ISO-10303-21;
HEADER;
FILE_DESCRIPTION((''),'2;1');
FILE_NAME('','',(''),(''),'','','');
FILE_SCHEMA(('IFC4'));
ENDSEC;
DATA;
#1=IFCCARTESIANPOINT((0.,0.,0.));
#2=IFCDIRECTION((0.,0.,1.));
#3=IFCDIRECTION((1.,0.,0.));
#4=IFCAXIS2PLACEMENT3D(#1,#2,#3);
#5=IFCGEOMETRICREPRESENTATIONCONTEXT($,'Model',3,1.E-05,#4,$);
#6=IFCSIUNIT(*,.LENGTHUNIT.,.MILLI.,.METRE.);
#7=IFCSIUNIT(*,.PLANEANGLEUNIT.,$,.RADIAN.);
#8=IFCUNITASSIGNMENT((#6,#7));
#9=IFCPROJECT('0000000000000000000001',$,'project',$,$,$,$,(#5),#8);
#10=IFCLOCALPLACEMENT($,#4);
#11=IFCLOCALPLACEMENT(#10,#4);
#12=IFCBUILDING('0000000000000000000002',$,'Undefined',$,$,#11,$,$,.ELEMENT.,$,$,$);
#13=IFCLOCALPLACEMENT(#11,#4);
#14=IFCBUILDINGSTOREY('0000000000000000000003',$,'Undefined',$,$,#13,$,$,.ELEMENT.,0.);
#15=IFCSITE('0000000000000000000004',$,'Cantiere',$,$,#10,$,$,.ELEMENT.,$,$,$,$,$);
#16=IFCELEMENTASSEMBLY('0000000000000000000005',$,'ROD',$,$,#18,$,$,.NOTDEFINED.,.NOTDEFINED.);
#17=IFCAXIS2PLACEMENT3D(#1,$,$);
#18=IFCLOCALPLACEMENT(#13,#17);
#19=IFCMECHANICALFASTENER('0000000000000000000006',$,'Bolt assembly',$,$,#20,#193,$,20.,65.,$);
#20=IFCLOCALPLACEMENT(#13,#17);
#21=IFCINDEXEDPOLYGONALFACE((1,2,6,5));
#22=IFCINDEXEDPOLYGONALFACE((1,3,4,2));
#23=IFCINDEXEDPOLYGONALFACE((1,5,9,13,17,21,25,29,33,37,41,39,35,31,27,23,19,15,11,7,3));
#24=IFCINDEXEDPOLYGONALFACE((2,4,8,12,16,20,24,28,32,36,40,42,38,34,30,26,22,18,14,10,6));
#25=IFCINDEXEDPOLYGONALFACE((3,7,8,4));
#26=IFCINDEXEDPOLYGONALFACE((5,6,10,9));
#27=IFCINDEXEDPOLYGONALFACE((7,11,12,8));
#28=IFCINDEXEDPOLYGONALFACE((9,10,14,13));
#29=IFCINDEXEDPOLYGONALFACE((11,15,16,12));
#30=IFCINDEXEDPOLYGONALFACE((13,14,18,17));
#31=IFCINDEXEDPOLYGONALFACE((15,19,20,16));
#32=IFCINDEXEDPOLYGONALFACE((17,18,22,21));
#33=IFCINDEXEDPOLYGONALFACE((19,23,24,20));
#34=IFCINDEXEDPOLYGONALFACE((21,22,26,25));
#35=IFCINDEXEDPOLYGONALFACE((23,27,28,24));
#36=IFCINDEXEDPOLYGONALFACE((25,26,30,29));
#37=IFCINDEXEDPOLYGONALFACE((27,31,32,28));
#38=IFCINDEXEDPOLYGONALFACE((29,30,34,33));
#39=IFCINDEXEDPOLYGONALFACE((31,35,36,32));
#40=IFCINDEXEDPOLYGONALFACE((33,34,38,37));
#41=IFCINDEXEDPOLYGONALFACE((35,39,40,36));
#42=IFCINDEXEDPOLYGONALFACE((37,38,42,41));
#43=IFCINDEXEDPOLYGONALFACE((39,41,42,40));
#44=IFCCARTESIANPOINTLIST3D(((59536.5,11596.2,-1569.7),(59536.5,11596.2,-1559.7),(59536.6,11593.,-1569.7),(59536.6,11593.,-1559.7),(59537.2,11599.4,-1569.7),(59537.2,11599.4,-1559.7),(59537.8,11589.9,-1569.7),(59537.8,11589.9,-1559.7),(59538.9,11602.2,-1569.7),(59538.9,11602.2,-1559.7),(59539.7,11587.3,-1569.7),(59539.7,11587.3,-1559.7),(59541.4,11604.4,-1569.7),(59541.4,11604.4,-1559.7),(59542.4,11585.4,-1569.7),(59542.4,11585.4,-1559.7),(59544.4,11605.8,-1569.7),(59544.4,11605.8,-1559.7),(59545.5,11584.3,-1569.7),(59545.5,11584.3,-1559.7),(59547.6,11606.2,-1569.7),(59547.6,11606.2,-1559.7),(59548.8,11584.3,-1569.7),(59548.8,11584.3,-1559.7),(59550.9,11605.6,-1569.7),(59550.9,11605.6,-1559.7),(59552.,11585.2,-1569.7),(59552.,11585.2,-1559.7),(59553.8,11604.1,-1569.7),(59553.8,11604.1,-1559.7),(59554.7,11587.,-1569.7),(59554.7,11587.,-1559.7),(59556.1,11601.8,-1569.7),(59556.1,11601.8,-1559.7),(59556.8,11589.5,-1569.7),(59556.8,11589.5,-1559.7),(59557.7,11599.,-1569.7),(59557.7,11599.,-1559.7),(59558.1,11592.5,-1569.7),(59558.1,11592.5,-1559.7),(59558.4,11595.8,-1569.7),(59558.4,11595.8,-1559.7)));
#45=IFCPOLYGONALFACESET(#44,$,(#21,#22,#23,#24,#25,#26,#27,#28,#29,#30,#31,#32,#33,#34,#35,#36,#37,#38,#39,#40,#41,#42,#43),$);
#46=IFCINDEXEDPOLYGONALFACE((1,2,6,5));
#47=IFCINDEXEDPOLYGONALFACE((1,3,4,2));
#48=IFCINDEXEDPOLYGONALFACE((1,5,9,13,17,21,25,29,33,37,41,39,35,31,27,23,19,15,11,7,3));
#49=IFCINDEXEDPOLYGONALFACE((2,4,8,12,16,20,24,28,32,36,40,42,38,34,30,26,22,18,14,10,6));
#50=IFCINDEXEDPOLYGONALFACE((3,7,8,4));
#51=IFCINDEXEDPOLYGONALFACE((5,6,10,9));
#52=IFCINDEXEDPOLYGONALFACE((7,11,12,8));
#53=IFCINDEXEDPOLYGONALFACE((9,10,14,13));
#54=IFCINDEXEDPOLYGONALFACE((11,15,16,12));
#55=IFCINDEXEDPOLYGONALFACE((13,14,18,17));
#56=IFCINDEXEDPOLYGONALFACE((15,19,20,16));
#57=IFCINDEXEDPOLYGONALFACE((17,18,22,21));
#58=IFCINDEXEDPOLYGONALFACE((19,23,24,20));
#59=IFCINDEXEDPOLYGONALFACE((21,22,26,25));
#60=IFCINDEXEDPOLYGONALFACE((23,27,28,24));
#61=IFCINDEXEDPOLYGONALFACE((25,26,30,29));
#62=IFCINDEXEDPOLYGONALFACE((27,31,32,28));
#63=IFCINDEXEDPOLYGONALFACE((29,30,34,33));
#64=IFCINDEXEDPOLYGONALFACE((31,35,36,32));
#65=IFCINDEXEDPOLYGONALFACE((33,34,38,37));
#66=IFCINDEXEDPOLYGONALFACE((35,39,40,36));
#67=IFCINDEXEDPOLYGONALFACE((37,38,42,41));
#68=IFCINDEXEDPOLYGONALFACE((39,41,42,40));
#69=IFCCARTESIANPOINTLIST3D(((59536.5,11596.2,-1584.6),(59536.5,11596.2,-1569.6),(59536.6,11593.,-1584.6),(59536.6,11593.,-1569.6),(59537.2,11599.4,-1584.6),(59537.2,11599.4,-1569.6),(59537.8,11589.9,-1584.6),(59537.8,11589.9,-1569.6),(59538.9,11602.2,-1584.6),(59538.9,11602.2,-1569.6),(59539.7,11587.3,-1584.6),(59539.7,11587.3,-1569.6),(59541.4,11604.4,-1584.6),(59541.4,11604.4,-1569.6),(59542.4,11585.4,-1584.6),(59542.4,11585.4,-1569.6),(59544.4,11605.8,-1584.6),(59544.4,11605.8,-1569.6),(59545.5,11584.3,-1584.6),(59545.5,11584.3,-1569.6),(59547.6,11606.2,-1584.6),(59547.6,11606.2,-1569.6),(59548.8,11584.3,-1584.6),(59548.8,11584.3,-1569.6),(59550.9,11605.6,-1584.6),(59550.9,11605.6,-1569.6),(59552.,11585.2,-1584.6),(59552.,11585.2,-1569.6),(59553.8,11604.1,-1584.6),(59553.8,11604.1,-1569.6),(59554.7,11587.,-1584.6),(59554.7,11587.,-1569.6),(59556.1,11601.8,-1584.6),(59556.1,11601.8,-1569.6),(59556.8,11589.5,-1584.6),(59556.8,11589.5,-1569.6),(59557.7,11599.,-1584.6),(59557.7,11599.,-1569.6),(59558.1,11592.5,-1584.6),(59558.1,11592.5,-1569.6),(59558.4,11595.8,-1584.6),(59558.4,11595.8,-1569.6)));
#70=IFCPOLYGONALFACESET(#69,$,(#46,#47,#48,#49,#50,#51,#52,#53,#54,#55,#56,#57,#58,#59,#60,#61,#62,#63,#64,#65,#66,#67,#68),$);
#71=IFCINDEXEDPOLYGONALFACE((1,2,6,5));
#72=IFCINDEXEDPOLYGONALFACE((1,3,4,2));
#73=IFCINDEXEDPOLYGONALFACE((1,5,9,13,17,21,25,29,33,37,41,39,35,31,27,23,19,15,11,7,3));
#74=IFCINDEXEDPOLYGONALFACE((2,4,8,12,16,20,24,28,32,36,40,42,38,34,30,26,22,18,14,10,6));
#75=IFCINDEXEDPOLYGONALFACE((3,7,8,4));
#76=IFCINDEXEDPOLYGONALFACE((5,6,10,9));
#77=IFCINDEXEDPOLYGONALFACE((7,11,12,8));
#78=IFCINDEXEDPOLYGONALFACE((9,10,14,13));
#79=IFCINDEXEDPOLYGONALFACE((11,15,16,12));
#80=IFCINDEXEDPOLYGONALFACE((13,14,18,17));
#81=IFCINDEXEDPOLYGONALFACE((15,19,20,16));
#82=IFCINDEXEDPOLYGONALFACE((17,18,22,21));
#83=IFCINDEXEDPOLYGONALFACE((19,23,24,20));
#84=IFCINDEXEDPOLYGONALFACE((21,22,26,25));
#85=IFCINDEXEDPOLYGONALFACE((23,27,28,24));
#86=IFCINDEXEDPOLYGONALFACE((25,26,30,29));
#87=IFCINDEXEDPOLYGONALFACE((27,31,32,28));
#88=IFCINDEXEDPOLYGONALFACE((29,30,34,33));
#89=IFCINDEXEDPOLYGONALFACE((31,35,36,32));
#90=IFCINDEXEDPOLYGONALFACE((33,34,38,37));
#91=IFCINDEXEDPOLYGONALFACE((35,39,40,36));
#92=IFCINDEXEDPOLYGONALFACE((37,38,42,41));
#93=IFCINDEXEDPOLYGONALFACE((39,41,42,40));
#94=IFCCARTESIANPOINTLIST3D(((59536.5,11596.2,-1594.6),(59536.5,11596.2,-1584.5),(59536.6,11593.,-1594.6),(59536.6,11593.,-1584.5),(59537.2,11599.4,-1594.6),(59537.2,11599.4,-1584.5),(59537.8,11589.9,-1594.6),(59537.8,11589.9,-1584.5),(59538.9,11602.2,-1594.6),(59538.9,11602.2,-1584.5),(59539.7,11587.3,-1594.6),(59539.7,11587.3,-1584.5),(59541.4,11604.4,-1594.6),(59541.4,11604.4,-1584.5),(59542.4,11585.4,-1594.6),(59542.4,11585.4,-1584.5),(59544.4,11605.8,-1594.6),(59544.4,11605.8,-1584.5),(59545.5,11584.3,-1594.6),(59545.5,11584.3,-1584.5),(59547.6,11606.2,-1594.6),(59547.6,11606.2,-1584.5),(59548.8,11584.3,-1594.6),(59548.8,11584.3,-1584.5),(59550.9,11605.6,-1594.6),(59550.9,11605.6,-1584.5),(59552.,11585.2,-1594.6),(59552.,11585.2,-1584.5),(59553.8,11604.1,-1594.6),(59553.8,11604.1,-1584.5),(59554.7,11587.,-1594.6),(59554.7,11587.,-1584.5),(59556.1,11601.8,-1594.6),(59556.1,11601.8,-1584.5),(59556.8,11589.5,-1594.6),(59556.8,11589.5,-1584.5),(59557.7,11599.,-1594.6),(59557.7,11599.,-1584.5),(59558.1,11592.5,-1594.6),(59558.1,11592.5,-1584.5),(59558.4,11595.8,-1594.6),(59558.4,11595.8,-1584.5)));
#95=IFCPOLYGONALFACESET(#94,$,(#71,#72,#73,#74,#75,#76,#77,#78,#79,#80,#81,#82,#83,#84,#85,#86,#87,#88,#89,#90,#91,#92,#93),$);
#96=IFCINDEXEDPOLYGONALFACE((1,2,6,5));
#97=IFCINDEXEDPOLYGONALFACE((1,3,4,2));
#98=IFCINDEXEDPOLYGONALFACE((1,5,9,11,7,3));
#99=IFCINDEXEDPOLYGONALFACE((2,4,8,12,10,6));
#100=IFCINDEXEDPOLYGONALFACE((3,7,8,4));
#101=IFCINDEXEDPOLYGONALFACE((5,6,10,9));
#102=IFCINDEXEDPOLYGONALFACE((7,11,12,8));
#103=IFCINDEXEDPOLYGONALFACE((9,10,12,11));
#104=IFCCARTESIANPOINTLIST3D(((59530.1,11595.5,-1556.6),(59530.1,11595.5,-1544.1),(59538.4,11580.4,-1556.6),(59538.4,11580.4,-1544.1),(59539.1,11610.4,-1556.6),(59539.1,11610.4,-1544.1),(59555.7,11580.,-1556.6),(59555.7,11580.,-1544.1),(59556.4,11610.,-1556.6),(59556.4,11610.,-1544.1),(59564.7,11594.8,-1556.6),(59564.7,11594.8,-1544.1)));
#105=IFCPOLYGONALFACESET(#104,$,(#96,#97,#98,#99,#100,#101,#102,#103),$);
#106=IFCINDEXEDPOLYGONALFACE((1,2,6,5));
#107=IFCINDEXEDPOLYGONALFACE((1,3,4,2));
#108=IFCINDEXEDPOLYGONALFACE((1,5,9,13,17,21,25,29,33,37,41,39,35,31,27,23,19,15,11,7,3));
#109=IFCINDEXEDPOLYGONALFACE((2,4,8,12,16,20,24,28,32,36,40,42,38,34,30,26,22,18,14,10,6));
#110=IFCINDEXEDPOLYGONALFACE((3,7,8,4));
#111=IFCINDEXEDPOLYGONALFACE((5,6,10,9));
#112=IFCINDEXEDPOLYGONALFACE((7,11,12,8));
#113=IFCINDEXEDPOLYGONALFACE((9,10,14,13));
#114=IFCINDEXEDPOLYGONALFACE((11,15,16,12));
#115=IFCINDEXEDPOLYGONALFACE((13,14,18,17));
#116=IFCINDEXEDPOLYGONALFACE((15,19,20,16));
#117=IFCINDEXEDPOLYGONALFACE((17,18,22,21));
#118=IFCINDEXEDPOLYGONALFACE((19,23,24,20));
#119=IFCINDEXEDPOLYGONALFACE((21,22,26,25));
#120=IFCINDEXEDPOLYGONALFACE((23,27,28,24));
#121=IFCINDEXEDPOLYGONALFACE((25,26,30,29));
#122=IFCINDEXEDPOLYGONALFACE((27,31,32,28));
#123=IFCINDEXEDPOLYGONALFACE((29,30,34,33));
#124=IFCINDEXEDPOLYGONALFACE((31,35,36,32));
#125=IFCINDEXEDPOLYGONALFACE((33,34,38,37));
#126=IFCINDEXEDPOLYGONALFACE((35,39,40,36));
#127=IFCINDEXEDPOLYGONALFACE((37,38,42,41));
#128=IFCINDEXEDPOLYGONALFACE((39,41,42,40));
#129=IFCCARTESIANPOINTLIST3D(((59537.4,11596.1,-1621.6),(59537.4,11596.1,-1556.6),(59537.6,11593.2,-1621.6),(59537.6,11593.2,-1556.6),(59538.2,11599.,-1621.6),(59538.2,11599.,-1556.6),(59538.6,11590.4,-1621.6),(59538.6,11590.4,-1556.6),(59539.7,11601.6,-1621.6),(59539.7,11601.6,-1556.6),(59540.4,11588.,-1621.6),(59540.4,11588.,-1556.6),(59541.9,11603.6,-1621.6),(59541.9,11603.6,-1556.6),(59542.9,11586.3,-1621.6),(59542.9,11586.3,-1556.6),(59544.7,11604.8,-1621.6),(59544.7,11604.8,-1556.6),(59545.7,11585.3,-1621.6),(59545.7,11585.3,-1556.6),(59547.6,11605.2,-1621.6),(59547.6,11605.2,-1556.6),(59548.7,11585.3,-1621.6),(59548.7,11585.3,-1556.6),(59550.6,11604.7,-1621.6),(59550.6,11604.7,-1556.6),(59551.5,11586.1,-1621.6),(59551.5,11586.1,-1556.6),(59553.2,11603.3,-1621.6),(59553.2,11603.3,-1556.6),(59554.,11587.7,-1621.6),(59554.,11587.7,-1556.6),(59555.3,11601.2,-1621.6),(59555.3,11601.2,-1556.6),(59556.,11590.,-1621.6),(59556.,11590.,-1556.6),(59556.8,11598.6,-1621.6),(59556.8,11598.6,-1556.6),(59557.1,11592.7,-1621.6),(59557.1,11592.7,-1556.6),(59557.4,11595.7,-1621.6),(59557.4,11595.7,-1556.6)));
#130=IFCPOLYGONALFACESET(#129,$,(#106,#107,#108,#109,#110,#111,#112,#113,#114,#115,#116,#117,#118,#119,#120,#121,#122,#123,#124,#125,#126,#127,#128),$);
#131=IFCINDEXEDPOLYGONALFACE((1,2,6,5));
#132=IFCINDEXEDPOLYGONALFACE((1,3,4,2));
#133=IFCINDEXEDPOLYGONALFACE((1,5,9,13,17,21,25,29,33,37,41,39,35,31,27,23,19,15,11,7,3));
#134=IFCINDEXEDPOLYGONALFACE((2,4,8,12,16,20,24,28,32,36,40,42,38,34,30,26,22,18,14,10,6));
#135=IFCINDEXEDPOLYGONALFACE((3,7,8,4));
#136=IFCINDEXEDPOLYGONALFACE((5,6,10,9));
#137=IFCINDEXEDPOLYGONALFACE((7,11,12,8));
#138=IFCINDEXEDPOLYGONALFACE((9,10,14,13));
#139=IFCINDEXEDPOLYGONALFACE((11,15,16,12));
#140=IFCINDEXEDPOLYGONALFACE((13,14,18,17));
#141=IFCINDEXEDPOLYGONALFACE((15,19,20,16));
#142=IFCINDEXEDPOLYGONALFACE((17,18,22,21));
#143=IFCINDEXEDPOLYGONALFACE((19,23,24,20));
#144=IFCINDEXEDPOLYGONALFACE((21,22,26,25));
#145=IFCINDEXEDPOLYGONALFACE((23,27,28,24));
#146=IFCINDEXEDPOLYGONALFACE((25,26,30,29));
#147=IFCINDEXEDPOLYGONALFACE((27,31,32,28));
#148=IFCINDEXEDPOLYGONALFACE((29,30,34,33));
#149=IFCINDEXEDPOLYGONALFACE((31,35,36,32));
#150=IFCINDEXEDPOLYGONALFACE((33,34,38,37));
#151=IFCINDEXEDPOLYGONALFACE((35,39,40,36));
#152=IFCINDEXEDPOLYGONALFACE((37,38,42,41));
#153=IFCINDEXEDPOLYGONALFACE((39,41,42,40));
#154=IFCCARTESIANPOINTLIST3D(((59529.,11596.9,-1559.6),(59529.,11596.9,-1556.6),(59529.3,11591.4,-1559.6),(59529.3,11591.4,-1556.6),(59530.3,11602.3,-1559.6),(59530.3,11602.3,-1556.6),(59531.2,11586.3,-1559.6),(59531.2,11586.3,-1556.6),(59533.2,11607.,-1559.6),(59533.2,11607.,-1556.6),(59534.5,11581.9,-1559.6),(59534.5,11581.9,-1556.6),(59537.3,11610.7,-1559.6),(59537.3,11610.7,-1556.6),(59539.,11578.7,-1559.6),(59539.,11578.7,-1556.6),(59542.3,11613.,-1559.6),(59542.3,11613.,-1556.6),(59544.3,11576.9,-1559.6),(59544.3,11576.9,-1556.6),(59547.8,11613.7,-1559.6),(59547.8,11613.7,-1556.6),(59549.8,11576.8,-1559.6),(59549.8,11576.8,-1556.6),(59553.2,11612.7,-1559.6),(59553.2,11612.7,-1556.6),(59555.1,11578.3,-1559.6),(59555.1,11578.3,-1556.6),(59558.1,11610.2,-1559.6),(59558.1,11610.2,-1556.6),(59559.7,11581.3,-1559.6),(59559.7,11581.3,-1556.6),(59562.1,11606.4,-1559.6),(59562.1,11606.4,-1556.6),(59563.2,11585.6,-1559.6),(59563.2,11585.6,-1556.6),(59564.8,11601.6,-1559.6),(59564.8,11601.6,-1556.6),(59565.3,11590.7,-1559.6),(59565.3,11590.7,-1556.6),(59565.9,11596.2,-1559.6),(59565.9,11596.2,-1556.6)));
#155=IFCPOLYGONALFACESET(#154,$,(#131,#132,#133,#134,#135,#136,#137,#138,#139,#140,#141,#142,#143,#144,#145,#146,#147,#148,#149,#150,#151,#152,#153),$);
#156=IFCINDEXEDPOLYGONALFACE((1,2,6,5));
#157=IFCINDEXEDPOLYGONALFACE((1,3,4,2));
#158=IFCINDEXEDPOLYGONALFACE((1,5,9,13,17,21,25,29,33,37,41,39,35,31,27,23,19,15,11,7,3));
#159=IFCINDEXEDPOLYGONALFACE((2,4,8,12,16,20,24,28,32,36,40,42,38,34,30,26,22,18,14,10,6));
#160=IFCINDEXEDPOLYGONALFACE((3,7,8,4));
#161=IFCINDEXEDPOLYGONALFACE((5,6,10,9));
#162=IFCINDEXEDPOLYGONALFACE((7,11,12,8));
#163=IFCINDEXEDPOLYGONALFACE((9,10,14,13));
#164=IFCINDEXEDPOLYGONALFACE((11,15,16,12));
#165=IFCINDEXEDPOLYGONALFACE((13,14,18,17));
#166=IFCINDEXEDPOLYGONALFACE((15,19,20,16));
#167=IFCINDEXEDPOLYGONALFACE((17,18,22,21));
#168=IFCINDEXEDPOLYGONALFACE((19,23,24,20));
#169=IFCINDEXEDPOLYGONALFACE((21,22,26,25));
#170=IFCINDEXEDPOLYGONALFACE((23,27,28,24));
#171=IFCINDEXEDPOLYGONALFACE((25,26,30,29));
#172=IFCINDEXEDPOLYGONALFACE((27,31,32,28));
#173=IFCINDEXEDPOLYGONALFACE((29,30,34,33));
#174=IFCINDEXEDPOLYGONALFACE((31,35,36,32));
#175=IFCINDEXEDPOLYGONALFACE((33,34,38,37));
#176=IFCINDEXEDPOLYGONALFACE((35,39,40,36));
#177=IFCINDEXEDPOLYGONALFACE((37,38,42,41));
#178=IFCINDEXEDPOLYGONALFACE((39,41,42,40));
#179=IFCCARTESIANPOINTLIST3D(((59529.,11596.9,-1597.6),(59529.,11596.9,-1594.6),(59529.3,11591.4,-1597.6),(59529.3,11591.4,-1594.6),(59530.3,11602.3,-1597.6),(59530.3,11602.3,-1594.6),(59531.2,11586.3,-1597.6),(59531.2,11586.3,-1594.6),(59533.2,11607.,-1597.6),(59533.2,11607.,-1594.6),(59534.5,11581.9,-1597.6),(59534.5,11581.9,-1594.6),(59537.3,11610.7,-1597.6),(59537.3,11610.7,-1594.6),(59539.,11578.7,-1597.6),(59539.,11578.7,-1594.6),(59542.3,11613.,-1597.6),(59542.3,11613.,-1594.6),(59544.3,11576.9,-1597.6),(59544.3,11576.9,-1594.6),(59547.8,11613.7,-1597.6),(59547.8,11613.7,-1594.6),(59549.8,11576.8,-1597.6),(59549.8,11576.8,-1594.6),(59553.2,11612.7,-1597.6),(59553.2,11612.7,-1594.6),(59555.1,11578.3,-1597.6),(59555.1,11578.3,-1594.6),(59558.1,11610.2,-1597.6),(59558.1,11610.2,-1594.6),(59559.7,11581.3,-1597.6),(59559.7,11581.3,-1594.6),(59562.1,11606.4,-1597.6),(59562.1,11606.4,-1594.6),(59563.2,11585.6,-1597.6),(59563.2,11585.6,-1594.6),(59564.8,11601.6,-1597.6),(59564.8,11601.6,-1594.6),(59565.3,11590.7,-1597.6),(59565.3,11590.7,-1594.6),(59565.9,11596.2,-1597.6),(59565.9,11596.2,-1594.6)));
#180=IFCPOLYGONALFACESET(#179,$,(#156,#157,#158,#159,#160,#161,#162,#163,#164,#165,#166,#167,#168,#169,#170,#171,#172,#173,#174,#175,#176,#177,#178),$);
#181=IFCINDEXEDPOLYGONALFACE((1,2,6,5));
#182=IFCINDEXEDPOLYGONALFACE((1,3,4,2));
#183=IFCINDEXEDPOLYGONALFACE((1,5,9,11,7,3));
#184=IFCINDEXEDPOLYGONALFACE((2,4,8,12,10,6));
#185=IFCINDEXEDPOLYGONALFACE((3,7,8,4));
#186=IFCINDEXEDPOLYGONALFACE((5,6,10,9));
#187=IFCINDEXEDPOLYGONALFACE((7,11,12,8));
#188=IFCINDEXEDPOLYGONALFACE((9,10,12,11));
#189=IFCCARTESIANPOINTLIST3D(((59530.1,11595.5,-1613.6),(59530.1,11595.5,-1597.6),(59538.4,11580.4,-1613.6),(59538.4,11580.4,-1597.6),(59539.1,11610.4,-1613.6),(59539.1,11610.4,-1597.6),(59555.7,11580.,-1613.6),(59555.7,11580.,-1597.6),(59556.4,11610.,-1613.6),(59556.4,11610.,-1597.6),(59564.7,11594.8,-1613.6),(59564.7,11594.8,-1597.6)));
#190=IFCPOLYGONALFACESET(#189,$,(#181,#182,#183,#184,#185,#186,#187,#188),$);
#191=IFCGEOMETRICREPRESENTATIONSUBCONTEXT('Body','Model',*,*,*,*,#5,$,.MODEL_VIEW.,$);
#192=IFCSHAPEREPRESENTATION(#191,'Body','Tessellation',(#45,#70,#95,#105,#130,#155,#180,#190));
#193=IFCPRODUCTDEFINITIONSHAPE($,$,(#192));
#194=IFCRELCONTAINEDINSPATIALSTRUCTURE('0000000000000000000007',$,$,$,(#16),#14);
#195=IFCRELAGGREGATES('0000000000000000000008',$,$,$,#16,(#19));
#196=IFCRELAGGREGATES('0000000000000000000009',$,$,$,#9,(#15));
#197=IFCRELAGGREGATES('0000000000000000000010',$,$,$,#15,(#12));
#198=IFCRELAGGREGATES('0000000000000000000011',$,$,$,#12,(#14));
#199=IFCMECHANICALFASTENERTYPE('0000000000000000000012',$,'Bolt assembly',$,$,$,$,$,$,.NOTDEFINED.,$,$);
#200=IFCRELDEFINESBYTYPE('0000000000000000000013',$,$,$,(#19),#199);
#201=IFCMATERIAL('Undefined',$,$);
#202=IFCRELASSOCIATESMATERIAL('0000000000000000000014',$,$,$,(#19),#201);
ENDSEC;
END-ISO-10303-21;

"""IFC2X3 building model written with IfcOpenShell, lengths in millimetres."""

from ifc_helpers import new_model, si_unit, frame, origin_with_axes, origin_2d_with_axis, place, context, subcontext, project, spatial, polyline, circle, outline, extrude, source, transform, mapped, material, type_object, element, aggregate, save


model = new_model("IFC2X3")

# Units and contexts
model_context = context("Model", 3, precision=1e-05, world=origin_with_axes())
body_context = subcontext(model_context, "Body", "Model", "MODEL_VIEW")
ifc_project = project(units=[si_unit("LENGTHUNIT", "METRE", prefix="MILLI"), si_unit("PLANEANGLEUNIT", "RADIAN")], contexts=[model_context])

# Site, building, storey
site_placement = place(None, origin_with_axes())
site = spatial("IfcSite", under=ifc_project, at=site_placement, Name="Cantiere", CompositionType="ELEMENT")
building_placement = place(site_placement, origin_with_axes())
building = spatial("IfcBuilding", under=site, at=building_placement, Name="Undefined", CompositionType="ELEMENT")
storey_placement = place(building_placement, origin_with_axes())
storey = spatial("IfcBuildingStorey", under=building, at=storey_placement, Name="Undefined", CompositionType="ELEMENT", Elevation=0.0)

# Element assembly
assembly_1_placement = place(storey_placement, origin_with_axes())
assembly_1 = element("IfcElementAssembly", 1, at=assembly_1_placement, inside=storey, Name="ROD", AssemblyPlace="NOTDEFINED", PredefinedType="NOTDEFINED")

# Mechanical fastener
ifc_material_1 = material(Name="Undefined")
mechanical_fastener_type = type_object("IfcMechanicalFastenerType", Name="Bolt assembly")
shared_shape_1 = source(origin_with_axes(), body_context, "Body", "SweptSolid", [
    extrude(circle(Radius=11.0, at=origin_2d_with_axis()), frame((0.0, 0.1, 0.0), z_axis=(0.0, 1.0, 0.0), x_axis=(1.0, 0.0, 0.0)), (0.0, 0.0, 1.0), 10.0),
    extrude(circle(Radius=11.0, at=origin_2d_with_axis()), frame((0.0, 10.0, 0.0), z_axis=(0.0, 1.0, 0.0), x_axis=(1.0, 0.0, 0.0)), (0.0, 0.0, 1.0), 15.0),
    extrude(circle(Radius=11.0, at=origin_2d_with_axis()), frame((0.0, 24.9, 0.0), z_axis=(0.0, 1.0, 0.0), x_axis=(1.0, 0.0, 0.0)), (0.0, 0.0, 1.0), 10.1),
    extrude(outline(polyline([(15.0, -8.7), (15.0, 8.7), (0.0, 17.3), (-15.0, 8.7), (-15.0, -8.7), (0.0, -17.3), (15.0, -8.7)])), frame((0.0, -15.5, 0.0), z_axis=(0.0, 1.0, 0.0), x_axis=(1.0, 0.0, 0.0)), (0.0, 0.0, 1.0), 12.5),
    extrude(circle(Radius=10.0, at=origin_2d_with_axis()), frame((0.0, -3.0, 0.0), z_axis=(0.0, 1.0, 0.0), x_axis=(1.0, 0.0, 0.0)), (0.0, 0.0, 1.0), 65.0),
    extrude(circle(Radius=18.5, at=origin_2d_with_axis()), frame((0.0, -3.0, 0.0), z_axis=(0.0, 1.0, 0.0), x_axis=(1.0, 0.0, 0.0)), (0.0, 0.0, 1.0), 3.0),
    extrude(circle(Radius=18.5, at=origin_2d_with_axis()), frame((0.0, 35.0, 0.0), z_axis=(0.0, 1.0, 0.0), x_axis=(1.0, 0.0, 0.0)), (0.0, 0.0, 1.0), 3.0),
    extrude(outline(polyline([(15.0, -8.7), (15.0, 8.7), (0.0, 17.3), (-15.0, 8.7), (-15.0, -8.7), (0.0, -17.3), (15.0, -8.7)])), frame((0.0, 38.0, 0.0), z_axis=(0.0, 1.0, 0.0), x_axis=(1.0, 0.0, 0.0)), (0.0, 0.0, 1.0), 16.0),
])
mechanical_fastener_1_placement = place(assembly_1_placement, frame((59547.4, 11595.2, -1559.6), z_axis=(-0.999775, 0.021213, 0.0), x_axis=(0.021213, 0.999775, 0.0)))
mechanical_fastener_1 = element("IfcMechanicalFastener", 2, at=mechanical_fastener_1_placement, type_object=mechanical_fastener_type, material=ifc_material_1, Name="Bolt assembly", NominalDiameter=20.0, NominalLength=65.0, context=body_context, shape_type="MappedRepresentation", body=[
    mapped(shared_shape_1, transform((0.0, 0.0, 0.0))),
])
aggregate(assembly_1, [mechanical_fastener_1])

save(model, "model.ifc")
